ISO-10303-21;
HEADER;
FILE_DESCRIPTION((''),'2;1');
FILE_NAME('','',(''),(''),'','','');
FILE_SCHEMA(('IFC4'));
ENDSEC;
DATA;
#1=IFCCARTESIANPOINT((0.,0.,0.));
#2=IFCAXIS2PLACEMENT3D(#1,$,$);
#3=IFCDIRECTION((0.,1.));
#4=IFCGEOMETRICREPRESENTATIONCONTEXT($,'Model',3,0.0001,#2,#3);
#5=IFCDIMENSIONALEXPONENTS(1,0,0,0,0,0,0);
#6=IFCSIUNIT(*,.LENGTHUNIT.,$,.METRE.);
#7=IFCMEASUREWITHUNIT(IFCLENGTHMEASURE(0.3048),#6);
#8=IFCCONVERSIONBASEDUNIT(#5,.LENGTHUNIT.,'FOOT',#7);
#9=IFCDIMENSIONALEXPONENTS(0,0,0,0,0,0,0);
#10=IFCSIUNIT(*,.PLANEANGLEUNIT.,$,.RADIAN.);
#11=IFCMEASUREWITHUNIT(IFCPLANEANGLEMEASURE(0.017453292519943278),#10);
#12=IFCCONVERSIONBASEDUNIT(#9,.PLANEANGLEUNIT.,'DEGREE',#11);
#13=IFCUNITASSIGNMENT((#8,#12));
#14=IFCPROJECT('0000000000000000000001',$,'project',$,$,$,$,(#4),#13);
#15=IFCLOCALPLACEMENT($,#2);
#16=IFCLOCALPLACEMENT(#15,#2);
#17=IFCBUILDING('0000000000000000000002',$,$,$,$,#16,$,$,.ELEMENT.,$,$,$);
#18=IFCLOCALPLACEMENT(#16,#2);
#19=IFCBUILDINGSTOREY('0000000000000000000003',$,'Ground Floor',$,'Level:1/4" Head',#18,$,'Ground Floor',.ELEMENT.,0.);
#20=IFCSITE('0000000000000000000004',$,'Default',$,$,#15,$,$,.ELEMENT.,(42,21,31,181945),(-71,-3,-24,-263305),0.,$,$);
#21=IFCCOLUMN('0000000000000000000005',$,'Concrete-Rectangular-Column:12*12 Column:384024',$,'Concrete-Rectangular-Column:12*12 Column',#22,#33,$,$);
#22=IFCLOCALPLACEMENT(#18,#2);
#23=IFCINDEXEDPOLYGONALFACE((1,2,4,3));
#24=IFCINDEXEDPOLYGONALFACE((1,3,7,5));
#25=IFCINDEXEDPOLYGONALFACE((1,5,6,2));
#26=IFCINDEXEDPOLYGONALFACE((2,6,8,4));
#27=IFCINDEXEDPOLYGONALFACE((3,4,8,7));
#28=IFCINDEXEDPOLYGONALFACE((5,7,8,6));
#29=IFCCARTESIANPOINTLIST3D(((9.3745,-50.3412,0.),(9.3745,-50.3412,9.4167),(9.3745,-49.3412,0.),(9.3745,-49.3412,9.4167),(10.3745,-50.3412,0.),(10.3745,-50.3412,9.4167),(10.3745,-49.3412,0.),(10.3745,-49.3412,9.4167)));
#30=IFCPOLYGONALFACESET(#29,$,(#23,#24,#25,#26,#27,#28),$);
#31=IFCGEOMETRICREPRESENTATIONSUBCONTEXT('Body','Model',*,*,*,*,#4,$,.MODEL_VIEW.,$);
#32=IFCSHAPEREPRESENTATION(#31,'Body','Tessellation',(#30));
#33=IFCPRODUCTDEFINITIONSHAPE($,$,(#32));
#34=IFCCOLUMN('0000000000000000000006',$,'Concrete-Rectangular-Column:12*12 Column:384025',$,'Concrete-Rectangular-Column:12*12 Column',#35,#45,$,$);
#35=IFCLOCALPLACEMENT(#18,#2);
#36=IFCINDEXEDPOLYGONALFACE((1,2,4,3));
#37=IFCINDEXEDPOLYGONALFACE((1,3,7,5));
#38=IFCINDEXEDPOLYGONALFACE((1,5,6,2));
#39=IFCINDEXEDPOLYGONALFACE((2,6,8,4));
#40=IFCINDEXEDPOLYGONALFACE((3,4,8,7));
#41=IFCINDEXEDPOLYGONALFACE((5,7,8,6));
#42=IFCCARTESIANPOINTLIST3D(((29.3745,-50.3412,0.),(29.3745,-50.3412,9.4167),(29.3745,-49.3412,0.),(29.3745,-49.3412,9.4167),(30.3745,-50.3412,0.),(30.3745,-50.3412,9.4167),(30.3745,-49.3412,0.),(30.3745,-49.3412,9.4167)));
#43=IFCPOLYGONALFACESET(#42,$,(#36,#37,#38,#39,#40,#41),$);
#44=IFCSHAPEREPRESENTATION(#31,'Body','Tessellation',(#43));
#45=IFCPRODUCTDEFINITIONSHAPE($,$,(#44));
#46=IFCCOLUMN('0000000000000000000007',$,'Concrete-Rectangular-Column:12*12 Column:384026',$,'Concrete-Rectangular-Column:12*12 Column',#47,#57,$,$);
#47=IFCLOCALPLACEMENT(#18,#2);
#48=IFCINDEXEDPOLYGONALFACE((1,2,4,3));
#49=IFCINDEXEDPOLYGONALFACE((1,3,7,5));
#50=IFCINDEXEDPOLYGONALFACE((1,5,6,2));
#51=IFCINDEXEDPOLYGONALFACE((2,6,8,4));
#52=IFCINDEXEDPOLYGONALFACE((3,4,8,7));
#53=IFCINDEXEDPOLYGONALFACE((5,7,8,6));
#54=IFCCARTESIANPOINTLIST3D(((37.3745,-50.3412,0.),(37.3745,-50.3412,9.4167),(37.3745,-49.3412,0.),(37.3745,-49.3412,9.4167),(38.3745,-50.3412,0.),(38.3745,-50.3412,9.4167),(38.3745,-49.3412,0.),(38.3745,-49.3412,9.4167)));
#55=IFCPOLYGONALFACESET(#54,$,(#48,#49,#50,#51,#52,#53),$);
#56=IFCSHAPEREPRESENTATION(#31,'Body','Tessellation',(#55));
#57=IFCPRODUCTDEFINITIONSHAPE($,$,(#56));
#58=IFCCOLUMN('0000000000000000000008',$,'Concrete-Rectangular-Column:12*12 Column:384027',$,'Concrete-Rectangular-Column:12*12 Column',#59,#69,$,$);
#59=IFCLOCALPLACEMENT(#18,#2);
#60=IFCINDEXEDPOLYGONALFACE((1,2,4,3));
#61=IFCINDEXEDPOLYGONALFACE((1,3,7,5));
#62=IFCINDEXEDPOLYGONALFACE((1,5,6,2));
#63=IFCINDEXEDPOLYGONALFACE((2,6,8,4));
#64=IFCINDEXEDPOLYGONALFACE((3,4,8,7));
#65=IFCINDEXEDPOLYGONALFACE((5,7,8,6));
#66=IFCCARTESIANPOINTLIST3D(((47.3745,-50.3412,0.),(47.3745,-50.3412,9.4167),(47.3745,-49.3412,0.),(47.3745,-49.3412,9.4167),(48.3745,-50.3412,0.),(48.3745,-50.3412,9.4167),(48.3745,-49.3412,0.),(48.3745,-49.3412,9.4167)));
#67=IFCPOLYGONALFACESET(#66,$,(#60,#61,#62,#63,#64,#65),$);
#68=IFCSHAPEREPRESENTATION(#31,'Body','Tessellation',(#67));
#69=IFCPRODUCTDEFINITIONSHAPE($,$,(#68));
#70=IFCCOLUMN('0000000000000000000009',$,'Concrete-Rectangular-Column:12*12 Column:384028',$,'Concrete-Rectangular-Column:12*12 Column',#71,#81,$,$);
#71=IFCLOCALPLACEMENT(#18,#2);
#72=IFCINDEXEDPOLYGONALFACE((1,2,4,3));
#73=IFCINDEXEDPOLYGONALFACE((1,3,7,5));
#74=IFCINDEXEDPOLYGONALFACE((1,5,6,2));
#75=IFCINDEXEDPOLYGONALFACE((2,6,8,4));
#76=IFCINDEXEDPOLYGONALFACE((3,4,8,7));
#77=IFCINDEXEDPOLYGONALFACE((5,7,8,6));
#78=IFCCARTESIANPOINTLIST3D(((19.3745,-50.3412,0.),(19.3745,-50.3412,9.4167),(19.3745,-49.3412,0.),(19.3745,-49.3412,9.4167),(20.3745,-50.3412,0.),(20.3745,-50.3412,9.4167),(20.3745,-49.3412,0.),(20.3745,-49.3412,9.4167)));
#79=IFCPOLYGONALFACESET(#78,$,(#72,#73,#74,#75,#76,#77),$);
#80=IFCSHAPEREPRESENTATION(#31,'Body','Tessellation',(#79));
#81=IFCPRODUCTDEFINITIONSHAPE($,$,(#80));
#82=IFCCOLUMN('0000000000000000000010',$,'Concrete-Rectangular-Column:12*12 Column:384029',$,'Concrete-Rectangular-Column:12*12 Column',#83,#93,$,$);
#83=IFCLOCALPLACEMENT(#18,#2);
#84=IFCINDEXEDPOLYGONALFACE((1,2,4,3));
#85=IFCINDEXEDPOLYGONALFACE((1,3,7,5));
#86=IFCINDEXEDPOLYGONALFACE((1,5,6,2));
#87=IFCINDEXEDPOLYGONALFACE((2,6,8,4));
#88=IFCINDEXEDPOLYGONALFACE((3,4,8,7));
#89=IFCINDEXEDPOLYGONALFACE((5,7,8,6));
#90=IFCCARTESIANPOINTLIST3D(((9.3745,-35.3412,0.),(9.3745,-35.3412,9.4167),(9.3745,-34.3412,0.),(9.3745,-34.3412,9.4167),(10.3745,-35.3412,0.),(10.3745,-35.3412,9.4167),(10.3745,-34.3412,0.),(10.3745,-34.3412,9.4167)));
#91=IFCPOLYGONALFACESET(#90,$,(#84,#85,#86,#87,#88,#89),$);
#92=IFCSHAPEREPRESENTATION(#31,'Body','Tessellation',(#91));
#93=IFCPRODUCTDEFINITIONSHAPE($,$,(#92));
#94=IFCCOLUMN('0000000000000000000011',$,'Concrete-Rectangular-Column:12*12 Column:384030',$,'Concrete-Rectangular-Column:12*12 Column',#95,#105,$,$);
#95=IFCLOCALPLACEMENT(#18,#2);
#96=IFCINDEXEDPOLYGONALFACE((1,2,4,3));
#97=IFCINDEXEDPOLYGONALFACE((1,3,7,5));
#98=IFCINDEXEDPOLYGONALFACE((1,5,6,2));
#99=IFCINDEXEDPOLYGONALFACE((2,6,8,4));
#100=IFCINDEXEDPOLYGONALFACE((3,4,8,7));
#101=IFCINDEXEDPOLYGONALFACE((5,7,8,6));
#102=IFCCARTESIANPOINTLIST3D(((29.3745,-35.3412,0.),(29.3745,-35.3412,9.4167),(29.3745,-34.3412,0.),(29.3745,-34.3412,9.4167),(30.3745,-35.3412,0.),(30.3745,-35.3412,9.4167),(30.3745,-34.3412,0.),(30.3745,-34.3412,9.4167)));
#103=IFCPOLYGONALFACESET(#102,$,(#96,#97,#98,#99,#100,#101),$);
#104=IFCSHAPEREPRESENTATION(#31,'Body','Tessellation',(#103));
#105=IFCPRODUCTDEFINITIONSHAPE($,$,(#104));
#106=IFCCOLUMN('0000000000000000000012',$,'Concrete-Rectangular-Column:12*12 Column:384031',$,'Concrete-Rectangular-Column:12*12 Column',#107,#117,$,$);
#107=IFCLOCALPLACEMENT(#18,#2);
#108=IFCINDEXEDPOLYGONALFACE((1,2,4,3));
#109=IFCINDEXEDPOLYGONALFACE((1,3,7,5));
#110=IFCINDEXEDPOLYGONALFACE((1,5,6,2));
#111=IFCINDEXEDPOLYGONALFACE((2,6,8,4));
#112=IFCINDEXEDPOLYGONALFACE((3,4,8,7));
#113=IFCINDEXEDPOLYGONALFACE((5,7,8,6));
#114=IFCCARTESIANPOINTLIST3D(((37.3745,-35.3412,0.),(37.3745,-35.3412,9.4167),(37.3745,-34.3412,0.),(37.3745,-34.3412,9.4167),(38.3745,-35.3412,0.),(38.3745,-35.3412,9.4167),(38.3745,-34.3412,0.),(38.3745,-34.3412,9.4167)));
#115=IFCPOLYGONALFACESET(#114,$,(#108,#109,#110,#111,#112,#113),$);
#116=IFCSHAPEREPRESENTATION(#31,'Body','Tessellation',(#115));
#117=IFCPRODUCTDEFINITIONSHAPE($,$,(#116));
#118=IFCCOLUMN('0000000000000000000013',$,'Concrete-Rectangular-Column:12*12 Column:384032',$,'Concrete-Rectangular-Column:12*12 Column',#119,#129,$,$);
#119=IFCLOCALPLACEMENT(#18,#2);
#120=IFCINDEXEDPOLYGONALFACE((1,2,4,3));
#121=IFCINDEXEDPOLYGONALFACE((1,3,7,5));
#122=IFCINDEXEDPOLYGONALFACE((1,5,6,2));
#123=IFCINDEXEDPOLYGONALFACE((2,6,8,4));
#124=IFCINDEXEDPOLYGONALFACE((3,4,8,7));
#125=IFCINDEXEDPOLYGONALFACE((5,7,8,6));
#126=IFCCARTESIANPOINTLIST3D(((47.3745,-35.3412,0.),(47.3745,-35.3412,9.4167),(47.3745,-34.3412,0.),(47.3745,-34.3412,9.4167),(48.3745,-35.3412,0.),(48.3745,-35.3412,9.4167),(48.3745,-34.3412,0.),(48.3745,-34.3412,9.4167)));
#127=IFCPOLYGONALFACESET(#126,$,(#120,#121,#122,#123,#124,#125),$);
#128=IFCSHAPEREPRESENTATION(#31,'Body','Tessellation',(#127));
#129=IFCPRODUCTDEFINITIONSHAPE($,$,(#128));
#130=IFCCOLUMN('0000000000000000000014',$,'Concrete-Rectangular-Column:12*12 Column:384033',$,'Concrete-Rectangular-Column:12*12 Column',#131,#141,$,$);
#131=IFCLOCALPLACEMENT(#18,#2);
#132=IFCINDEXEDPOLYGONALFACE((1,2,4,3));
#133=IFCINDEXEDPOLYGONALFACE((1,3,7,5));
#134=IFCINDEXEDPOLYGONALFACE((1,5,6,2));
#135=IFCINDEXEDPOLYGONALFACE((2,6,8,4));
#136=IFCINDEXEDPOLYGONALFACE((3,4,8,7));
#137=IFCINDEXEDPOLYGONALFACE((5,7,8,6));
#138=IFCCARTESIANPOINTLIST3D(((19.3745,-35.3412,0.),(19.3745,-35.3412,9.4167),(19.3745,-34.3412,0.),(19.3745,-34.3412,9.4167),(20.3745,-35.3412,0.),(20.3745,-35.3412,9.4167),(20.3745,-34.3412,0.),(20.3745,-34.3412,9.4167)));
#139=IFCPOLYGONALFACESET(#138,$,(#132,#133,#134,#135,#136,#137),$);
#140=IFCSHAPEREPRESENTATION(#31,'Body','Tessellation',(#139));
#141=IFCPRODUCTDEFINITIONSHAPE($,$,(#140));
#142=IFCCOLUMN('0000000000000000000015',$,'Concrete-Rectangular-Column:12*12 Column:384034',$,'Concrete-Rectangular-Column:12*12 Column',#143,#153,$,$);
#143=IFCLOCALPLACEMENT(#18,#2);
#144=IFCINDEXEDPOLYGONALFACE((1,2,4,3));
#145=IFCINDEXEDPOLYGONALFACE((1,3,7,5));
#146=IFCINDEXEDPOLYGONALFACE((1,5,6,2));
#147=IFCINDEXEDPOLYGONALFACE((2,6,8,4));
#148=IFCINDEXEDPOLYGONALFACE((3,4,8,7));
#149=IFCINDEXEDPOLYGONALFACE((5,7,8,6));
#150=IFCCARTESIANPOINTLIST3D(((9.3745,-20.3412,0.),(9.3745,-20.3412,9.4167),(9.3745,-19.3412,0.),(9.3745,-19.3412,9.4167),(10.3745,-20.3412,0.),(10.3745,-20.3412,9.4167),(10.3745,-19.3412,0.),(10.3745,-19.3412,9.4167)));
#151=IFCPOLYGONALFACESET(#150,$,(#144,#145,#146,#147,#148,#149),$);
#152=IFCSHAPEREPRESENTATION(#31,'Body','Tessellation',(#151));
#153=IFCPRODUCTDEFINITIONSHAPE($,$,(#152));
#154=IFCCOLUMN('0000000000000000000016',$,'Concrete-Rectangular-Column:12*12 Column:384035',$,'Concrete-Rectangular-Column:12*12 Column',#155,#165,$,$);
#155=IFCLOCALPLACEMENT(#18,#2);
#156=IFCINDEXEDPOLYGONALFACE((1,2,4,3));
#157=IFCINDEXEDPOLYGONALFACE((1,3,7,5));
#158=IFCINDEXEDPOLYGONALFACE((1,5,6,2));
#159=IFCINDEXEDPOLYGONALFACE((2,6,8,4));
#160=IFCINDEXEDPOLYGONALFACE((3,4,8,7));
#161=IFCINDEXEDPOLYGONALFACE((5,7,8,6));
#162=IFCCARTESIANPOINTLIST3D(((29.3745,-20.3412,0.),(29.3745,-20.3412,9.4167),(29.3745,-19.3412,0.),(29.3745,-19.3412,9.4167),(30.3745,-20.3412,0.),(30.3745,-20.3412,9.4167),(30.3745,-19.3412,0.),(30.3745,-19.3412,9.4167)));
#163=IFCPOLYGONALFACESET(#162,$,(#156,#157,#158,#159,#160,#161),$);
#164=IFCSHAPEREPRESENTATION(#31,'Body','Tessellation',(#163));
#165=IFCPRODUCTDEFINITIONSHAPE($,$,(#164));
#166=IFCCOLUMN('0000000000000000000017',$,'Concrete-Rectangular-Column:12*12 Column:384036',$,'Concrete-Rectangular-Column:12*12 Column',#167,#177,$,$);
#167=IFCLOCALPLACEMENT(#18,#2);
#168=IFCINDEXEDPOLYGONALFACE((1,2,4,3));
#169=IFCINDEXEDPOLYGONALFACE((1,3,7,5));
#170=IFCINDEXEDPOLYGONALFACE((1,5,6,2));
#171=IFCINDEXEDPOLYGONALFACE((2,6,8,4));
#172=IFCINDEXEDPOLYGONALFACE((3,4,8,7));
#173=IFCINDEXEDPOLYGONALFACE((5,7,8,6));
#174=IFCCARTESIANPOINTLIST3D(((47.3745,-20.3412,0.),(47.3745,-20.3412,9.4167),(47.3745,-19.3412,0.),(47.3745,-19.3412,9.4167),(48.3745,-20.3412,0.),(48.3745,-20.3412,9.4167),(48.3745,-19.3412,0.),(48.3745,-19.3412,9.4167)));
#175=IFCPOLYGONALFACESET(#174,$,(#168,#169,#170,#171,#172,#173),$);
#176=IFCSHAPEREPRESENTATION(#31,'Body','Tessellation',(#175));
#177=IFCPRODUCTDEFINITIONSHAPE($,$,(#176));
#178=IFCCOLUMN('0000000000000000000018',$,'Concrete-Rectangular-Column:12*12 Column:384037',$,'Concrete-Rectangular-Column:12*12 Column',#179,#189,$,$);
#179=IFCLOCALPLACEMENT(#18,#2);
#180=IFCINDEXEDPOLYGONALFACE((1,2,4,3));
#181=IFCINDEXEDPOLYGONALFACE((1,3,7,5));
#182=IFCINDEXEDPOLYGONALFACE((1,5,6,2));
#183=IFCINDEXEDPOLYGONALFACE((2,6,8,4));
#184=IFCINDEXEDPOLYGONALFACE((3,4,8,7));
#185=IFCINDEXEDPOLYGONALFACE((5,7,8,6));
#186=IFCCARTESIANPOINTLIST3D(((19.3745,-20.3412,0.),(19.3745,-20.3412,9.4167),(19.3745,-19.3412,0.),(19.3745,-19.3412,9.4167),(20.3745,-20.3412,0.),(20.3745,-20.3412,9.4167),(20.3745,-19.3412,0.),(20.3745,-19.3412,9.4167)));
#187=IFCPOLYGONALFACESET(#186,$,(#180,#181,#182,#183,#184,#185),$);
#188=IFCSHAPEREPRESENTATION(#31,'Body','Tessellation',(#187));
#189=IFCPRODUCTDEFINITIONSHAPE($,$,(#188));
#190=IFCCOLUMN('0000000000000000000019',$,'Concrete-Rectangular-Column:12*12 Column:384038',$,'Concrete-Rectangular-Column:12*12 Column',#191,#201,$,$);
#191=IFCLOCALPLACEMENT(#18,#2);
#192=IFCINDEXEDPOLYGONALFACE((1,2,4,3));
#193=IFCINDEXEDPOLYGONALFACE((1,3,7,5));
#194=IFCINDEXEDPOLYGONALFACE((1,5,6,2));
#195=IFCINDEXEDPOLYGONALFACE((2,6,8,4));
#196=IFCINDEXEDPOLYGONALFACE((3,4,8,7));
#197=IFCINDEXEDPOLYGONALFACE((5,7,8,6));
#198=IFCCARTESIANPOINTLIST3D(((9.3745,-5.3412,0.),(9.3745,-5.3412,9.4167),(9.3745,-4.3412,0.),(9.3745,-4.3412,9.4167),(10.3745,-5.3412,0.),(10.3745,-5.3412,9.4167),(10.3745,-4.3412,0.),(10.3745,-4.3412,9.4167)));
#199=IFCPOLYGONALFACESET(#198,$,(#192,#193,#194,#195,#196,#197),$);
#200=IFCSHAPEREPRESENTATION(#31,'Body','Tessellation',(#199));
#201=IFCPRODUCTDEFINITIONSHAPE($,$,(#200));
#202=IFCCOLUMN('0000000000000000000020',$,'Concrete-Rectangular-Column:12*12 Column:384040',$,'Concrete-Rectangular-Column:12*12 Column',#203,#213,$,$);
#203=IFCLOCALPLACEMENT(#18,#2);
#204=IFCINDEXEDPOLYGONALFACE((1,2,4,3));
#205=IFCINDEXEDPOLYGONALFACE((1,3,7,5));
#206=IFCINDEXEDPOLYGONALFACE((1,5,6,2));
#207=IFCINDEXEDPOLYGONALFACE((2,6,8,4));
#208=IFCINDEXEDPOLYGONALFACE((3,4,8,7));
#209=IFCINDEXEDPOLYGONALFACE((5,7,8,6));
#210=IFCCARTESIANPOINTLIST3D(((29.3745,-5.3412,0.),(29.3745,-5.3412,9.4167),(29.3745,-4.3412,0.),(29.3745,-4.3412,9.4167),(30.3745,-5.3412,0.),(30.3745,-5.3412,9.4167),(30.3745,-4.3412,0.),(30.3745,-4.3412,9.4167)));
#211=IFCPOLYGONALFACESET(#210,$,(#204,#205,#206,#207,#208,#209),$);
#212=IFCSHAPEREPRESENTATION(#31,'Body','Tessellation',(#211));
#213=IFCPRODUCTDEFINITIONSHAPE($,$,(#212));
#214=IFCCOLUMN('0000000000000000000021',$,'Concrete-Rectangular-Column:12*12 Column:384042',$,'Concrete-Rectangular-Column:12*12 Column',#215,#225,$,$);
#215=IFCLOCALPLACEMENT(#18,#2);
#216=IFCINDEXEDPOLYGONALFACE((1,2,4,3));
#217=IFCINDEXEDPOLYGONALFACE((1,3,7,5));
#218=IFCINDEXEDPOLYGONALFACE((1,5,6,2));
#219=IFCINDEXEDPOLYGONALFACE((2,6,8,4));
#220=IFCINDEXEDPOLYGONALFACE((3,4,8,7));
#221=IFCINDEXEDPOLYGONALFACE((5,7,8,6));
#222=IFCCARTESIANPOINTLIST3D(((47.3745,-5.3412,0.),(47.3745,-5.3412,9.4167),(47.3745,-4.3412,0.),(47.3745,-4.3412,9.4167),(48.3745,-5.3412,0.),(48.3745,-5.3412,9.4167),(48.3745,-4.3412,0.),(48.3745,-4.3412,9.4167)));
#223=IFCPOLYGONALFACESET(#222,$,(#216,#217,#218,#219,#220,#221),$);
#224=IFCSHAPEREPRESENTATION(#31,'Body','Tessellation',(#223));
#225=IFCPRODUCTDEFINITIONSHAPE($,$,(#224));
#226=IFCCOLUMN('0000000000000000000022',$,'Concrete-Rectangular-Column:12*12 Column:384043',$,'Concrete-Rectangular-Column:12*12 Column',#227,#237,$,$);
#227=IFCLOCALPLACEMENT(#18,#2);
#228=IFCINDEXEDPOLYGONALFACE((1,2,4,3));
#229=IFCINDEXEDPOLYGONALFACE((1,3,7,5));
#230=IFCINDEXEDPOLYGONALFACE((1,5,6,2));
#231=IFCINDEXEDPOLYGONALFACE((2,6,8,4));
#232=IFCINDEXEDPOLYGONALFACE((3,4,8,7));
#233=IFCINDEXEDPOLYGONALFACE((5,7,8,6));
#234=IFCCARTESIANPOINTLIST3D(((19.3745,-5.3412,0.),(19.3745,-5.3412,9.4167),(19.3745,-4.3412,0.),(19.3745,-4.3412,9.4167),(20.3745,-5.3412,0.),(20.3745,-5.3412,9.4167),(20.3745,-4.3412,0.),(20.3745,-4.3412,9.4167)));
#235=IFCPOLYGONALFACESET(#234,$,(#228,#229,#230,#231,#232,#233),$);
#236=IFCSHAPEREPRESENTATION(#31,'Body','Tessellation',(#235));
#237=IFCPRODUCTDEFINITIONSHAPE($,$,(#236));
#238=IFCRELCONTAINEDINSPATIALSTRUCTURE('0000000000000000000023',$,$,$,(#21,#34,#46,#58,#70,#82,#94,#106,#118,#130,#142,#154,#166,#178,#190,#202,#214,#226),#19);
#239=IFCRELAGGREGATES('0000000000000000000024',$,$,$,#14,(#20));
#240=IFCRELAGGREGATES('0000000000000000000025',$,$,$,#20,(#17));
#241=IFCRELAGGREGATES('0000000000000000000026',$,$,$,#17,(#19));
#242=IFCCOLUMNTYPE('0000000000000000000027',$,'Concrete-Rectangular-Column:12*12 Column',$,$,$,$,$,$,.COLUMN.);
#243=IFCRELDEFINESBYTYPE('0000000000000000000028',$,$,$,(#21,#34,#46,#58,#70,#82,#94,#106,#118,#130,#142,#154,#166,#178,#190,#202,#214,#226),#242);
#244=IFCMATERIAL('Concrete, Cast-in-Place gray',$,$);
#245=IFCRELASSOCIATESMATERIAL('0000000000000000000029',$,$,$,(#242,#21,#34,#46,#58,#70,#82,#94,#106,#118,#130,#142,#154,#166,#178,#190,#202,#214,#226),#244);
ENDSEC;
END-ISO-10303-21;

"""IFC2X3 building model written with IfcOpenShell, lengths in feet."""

from ifc_helpers import new_model, entity, si_unit, converted_unit, direction, frame, origin, origin_2d_with_axis, place, context, subcontext, project, spatial, rectangle, extrude, source, transform, mapped, material, type_object, type_shapes, element, save


model = new_model("IFC2X3")

# Units and contexts
model_context = context("Model", 3, precision=0.0001, world=origin(), true_north=direction((0.0, 1.0)))
body_context = subcontext(model_context, "Body", "Model", "MODEL_VIEW")
ifc_project = project(units=[converted_unit("LENGTHUNIT", "FOOT", entity("IfcLengthMeasure", 0.3048), si_unit("LENGTHUNIT", "METRE"), dimensions=[1, 0, 0, 0, 0, 0, 0]), converted_unit("PLANEANGLEUNIT", "DEGREE", entity("IfcPlaneAngleMeasure", 0.017453292519943278), si_unit("PLANEANGLEUNIT", "RADIAN"), dimensions=[0, 0, 0, 0, 0, 0, 0])], contexts=[model_context])

# Site, building, storey
site_placement = place(None, origin())
site = spatial("IfcSite", under=ifc_project, at=site_placement, Name="Default", CompositionType="ELEMENT", RefLatitude=(42, 21, 31, 181945), RefLongitude=(-71, -3, -24, -263305), RefElevation=0.0)
building_placement = place(site_placement, origin())
building = spatial("IfcBuilding", under=site, at=building_placement, CompositionType="ELEMENT")
storey_placement = place(building_placement, origin())
storey = spatial("IfcBuildingStorey", under=building, at=storey_placement, Name="Ground Floor", ObjectType="Level:1/4\" Head", LongName="Ground Floor", CompositionType="ELEMENT", Elevation=0.0)

# Columns
ifc_material = material(Name="Concrete, Cast-in-Place gray")
column_type = type_object("IfcColumnType", Name="Concrete-Rectangular-Column:12*12 Column", PredefinedType="COLUMN", material=ifc_material)
shared_shape = source(origin(), body_context, "Body", "SweptSolid", [
    extrude(rectangle(XDim=1.0, YDim=1.0, at=origin_2d_with_axis()), frame((0.0, 0.0, 0.0), z_axis=(0.0, 0.0, 1.0), x_axis=(-1.0, 0.0, 0.0)), (0.0, 0.0, 1.0), 9.4167),
])
type_shapes(column_type, [shared_shape])
for number, where, name in (
    (1, (9.8745, -49.8412, 0.0), "Concrete-Rectangular-Column:12*12 Column:384024"),
    (2, (29.8745, -49.8412, 0.0), "Concrete-Rectangular-Column:12*12 Column:384025"),
    (3, (37.8745, -49.8412, 0.0), "Concrete-Rectangular-Column:12*12 Column:384026"),
    (4, (47.8745, -49.8412, 0.0), "Concrete-Rectangular-Column:12*12 Column:384027"),
    (5, (19.8745, -49.8412, 0.0), "Concrete-Rectangular-Column:12*12 Column:384028"),
    (6, (9.8745, -34.8412, 0.0), "Concrete-Rectangular-Column:12*12 Column:384029"),
    (7, (29.8745, -34.8412, 0.0), "Concrete-Rectangular-Column:12*12 Column:384030"),
    (8, (37.8745, -34.8412, 0.0), "Concrete-Rectangular-Column:12*12 Column:384031"),
    (9, (47.8745, -34.8412, 0.0), "Concrete-Rectangular-Column:12*12 Column:384032"),
    (10, (19.8745, -34.8412, 0.0), "Concrete-Rectangular-Column:12*12 Column:384033"),
    (11, (9.8745, -19.8412, 0.0), "Concrete-Rectangular-Column:12*12 Column:384034"),
    (12, (29.8745, -19.8412, 0.0), "Concrete-Rectangular-Column:12*12 Column:384035"),
    (13, (47.8745, -19.8412, 0.0), "Concrete-Rectangular-Column:12*12 Column:384036"),
    (14, (19.8745, -19.8412, 0.0), "Concrete-Rectangular-Column:12*12 Column:384037"),
    (15, (9.8745, -4.8412, 0.0), "Concrete-Rectangular-Column:12*12 Column:384038"),
    (16, (29.8745, -4.8412, 0.0), "Concrete-Rectangular-Column:12*12 Column:384040"),
    (17, (47.8745, -4.8412, 0.0), "Concrete-Rectangular-Column:12*12 Column:384042"),
    (18, (19.8745, -4.8412, 0.0), "Concrete-Rectangular-Column:12*12 Column:384043"),
):
    element("IfcColumn", number, at=place(storey_placement, frame(where)), inside=storey, type_object=column_type, material=ifc_material, Name=name, ObjectType="Concrete-Rectangular-Column:12*12 Column", context=body_context, shape_type="MappedRepresentation", body=[
        mapped(shared_shape, transform((0.0, 0.0, 0.0), scale=1.0)),
    ])

save(model, "model.ifc")
